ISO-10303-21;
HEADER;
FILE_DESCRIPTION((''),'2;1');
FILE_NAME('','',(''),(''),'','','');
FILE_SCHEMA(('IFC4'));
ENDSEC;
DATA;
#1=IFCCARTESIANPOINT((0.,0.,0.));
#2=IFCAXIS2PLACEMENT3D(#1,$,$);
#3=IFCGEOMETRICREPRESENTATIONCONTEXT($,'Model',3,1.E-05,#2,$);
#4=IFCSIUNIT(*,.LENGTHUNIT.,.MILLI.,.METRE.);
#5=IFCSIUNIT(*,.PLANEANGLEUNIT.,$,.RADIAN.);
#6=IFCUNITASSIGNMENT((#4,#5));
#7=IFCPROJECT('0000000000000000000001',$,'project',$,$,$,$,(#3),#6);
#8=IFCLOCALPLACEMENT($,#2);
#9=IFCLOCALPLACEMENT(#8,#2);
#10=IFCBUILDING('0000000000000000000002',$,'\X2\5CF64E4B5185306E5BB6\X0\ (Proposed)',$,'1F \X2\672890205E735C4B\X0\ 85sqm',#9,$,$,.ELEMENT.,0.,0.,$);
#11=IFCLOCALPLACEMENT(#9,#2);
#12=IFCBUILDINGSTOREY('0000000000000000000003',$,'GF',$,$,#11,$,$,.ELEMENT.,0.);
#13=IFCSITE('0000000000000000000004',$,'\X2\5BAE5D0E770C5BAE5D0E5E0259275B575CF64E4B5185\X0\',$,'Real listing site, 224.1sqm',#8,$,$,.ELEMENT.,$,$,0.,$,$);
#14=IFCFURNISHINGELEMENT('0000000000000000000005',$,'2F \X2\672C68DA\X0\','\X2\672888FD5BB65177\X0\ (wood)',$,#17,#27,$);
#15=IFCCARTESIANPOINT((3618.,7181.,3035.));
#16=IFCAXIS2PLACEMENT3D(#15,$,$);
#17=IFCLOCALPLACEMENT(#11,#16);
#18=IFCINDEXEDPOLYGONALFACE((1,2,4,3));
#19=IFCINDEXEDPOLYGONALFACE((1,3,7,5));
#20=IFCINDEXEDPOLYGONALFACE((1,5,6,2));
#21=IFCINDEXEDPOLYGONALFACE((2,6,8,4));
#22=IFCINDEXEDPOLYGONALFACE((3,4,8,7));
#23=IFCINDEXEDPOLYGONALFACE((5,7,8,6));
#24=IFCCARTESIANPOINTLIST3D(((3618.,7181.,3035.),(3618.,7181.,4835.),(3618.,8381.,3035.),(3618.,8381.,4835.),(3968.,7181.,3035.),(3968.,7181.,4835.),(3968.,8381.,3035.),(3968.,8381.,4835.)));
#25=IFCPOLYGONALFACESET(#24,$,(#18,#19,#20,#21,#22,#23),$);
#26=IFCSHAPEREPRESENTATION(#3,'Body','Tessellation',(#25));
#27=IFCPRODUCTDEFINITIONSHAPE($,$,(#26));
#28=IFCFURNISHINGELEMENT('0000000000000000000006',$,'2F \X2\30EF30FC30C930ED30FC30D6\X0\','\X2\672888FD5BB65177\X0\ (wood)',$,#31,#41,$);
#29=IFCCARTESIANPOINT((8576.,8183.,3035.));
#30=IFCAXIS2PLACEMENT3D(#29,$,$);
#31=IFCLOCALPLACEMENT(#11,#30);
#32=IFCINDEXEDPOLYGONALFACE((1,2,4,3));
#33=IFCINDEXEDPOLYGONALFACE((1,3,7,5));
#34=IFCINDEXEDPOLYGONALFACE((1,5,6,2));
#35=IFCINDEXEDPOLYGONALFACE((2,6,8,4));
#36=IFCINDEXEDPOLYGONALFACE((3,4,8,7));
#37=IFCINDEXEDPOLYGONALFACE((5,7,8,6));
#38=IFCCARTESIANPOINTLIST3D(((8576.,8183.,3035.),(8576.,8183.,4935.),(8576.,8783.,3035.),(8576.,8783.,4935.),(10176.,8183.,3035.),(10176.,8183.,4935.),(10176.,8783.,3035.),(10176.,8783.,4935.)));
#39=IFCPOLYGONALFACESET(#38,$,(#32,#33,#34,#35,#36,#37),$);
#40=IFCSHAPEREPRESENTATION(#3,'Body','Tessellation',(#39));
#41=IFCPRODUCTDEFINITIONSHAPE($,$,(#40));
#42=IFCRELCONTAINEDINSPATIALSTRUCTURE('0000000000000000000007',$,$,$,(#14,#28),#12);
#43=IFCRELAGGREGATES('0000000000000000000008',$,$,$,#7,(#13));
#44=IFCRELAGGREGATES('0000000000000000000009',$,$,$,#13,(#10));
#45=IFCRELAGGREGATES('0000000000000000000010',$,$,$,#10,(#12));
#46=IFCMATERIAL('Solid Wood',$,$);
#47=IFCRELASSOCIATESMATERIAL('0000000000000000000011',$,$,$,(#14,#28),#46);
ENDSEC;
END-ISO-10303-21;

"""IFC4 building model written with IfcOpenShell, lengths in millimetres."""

from ifc_helpers import new_model, si_unit, frame, frame_2d, origin, place, context, project, spatial, rectangle, extrude, material, element, save


model = new_model("IFC4")

# Units and contexts
model_context = context("Model", 3, precision=1e-05, world=origin())
ifc_project = project(units=[si_unit("LENGTHUNIT", "METRE", prefix="MILLI"), si_unit("PLANEANGLEUNIT", "RADIAN")], contexts=[model_context])

# Site, building, storey
site_placement = place(None, origin())
site = spatial("IfcSite", under=ifc_project, at=site_placement, Name="宮崎県宮崎市大字島之内", ObjectType="Real listing site, 224.1sqm", CompositionType="ELEMENT", RefElevation=0.0)
building_placement = place(site_placement, origin())
building = spatial("IfcBuilding", under=site, at=building_placement, Name="島之内の家 (Proposed)", ObjectType="1F 木造平屋 85sqm", CompositionType="ELEMENT", ElevationOfRefHeight=0.0, ElevationOfTerrain=0.0)
storey_placement = place(building_placement, origin())
storey = spatial("IfcBuildingStorey", under=building, at=storey_placement, Name="GF", CompositionType="ELEMENT", Elevation=0.0)

# Shared definitions
ifc_material_1 = material(Name="Solid Wood")

# Furnishing elements
furnishing_1_placement = place(storey_placement, frame((3618.0, 7181.0, 3035.0)))
element("IfcFurnishingElement", 1, at=furnishing_1_placement, inside=storey, material=ifc_material_1, Name="2F 本棚", Description="木製家具 (wood)", context=model_context, shape_type="SweptSolid", body=[
    extrude(rectangle(XDim=350.0, YDim=1200.0, at=frame_2d((175.0, 600.0))), frame((3618.0, 7181.0, 3035.0)), (0.0, 0.0, 1.0), 1800.0),
])
furnishing_2_placement = place(storey_placement, frame((8576.0, 8183.0, 3035.0)))
element("IfcFurnishingElement", 2, at=furnishing_2_placement, inside=storey, material=ifc_material_1, Name="2F ワードローブ", Description="木製家具 (wood)", context=model_context, shape_type="SweptSolid", body=[
    extrude(rectangle(XDim=1600.0, YDim=600.0, at=frame_2d((800.0, 300.0))), frame((8576.0, 8183.0, 3035.0)), (0.0, 0.0, 1.0), 1900.0),
])

save(model, "model.ifc")
